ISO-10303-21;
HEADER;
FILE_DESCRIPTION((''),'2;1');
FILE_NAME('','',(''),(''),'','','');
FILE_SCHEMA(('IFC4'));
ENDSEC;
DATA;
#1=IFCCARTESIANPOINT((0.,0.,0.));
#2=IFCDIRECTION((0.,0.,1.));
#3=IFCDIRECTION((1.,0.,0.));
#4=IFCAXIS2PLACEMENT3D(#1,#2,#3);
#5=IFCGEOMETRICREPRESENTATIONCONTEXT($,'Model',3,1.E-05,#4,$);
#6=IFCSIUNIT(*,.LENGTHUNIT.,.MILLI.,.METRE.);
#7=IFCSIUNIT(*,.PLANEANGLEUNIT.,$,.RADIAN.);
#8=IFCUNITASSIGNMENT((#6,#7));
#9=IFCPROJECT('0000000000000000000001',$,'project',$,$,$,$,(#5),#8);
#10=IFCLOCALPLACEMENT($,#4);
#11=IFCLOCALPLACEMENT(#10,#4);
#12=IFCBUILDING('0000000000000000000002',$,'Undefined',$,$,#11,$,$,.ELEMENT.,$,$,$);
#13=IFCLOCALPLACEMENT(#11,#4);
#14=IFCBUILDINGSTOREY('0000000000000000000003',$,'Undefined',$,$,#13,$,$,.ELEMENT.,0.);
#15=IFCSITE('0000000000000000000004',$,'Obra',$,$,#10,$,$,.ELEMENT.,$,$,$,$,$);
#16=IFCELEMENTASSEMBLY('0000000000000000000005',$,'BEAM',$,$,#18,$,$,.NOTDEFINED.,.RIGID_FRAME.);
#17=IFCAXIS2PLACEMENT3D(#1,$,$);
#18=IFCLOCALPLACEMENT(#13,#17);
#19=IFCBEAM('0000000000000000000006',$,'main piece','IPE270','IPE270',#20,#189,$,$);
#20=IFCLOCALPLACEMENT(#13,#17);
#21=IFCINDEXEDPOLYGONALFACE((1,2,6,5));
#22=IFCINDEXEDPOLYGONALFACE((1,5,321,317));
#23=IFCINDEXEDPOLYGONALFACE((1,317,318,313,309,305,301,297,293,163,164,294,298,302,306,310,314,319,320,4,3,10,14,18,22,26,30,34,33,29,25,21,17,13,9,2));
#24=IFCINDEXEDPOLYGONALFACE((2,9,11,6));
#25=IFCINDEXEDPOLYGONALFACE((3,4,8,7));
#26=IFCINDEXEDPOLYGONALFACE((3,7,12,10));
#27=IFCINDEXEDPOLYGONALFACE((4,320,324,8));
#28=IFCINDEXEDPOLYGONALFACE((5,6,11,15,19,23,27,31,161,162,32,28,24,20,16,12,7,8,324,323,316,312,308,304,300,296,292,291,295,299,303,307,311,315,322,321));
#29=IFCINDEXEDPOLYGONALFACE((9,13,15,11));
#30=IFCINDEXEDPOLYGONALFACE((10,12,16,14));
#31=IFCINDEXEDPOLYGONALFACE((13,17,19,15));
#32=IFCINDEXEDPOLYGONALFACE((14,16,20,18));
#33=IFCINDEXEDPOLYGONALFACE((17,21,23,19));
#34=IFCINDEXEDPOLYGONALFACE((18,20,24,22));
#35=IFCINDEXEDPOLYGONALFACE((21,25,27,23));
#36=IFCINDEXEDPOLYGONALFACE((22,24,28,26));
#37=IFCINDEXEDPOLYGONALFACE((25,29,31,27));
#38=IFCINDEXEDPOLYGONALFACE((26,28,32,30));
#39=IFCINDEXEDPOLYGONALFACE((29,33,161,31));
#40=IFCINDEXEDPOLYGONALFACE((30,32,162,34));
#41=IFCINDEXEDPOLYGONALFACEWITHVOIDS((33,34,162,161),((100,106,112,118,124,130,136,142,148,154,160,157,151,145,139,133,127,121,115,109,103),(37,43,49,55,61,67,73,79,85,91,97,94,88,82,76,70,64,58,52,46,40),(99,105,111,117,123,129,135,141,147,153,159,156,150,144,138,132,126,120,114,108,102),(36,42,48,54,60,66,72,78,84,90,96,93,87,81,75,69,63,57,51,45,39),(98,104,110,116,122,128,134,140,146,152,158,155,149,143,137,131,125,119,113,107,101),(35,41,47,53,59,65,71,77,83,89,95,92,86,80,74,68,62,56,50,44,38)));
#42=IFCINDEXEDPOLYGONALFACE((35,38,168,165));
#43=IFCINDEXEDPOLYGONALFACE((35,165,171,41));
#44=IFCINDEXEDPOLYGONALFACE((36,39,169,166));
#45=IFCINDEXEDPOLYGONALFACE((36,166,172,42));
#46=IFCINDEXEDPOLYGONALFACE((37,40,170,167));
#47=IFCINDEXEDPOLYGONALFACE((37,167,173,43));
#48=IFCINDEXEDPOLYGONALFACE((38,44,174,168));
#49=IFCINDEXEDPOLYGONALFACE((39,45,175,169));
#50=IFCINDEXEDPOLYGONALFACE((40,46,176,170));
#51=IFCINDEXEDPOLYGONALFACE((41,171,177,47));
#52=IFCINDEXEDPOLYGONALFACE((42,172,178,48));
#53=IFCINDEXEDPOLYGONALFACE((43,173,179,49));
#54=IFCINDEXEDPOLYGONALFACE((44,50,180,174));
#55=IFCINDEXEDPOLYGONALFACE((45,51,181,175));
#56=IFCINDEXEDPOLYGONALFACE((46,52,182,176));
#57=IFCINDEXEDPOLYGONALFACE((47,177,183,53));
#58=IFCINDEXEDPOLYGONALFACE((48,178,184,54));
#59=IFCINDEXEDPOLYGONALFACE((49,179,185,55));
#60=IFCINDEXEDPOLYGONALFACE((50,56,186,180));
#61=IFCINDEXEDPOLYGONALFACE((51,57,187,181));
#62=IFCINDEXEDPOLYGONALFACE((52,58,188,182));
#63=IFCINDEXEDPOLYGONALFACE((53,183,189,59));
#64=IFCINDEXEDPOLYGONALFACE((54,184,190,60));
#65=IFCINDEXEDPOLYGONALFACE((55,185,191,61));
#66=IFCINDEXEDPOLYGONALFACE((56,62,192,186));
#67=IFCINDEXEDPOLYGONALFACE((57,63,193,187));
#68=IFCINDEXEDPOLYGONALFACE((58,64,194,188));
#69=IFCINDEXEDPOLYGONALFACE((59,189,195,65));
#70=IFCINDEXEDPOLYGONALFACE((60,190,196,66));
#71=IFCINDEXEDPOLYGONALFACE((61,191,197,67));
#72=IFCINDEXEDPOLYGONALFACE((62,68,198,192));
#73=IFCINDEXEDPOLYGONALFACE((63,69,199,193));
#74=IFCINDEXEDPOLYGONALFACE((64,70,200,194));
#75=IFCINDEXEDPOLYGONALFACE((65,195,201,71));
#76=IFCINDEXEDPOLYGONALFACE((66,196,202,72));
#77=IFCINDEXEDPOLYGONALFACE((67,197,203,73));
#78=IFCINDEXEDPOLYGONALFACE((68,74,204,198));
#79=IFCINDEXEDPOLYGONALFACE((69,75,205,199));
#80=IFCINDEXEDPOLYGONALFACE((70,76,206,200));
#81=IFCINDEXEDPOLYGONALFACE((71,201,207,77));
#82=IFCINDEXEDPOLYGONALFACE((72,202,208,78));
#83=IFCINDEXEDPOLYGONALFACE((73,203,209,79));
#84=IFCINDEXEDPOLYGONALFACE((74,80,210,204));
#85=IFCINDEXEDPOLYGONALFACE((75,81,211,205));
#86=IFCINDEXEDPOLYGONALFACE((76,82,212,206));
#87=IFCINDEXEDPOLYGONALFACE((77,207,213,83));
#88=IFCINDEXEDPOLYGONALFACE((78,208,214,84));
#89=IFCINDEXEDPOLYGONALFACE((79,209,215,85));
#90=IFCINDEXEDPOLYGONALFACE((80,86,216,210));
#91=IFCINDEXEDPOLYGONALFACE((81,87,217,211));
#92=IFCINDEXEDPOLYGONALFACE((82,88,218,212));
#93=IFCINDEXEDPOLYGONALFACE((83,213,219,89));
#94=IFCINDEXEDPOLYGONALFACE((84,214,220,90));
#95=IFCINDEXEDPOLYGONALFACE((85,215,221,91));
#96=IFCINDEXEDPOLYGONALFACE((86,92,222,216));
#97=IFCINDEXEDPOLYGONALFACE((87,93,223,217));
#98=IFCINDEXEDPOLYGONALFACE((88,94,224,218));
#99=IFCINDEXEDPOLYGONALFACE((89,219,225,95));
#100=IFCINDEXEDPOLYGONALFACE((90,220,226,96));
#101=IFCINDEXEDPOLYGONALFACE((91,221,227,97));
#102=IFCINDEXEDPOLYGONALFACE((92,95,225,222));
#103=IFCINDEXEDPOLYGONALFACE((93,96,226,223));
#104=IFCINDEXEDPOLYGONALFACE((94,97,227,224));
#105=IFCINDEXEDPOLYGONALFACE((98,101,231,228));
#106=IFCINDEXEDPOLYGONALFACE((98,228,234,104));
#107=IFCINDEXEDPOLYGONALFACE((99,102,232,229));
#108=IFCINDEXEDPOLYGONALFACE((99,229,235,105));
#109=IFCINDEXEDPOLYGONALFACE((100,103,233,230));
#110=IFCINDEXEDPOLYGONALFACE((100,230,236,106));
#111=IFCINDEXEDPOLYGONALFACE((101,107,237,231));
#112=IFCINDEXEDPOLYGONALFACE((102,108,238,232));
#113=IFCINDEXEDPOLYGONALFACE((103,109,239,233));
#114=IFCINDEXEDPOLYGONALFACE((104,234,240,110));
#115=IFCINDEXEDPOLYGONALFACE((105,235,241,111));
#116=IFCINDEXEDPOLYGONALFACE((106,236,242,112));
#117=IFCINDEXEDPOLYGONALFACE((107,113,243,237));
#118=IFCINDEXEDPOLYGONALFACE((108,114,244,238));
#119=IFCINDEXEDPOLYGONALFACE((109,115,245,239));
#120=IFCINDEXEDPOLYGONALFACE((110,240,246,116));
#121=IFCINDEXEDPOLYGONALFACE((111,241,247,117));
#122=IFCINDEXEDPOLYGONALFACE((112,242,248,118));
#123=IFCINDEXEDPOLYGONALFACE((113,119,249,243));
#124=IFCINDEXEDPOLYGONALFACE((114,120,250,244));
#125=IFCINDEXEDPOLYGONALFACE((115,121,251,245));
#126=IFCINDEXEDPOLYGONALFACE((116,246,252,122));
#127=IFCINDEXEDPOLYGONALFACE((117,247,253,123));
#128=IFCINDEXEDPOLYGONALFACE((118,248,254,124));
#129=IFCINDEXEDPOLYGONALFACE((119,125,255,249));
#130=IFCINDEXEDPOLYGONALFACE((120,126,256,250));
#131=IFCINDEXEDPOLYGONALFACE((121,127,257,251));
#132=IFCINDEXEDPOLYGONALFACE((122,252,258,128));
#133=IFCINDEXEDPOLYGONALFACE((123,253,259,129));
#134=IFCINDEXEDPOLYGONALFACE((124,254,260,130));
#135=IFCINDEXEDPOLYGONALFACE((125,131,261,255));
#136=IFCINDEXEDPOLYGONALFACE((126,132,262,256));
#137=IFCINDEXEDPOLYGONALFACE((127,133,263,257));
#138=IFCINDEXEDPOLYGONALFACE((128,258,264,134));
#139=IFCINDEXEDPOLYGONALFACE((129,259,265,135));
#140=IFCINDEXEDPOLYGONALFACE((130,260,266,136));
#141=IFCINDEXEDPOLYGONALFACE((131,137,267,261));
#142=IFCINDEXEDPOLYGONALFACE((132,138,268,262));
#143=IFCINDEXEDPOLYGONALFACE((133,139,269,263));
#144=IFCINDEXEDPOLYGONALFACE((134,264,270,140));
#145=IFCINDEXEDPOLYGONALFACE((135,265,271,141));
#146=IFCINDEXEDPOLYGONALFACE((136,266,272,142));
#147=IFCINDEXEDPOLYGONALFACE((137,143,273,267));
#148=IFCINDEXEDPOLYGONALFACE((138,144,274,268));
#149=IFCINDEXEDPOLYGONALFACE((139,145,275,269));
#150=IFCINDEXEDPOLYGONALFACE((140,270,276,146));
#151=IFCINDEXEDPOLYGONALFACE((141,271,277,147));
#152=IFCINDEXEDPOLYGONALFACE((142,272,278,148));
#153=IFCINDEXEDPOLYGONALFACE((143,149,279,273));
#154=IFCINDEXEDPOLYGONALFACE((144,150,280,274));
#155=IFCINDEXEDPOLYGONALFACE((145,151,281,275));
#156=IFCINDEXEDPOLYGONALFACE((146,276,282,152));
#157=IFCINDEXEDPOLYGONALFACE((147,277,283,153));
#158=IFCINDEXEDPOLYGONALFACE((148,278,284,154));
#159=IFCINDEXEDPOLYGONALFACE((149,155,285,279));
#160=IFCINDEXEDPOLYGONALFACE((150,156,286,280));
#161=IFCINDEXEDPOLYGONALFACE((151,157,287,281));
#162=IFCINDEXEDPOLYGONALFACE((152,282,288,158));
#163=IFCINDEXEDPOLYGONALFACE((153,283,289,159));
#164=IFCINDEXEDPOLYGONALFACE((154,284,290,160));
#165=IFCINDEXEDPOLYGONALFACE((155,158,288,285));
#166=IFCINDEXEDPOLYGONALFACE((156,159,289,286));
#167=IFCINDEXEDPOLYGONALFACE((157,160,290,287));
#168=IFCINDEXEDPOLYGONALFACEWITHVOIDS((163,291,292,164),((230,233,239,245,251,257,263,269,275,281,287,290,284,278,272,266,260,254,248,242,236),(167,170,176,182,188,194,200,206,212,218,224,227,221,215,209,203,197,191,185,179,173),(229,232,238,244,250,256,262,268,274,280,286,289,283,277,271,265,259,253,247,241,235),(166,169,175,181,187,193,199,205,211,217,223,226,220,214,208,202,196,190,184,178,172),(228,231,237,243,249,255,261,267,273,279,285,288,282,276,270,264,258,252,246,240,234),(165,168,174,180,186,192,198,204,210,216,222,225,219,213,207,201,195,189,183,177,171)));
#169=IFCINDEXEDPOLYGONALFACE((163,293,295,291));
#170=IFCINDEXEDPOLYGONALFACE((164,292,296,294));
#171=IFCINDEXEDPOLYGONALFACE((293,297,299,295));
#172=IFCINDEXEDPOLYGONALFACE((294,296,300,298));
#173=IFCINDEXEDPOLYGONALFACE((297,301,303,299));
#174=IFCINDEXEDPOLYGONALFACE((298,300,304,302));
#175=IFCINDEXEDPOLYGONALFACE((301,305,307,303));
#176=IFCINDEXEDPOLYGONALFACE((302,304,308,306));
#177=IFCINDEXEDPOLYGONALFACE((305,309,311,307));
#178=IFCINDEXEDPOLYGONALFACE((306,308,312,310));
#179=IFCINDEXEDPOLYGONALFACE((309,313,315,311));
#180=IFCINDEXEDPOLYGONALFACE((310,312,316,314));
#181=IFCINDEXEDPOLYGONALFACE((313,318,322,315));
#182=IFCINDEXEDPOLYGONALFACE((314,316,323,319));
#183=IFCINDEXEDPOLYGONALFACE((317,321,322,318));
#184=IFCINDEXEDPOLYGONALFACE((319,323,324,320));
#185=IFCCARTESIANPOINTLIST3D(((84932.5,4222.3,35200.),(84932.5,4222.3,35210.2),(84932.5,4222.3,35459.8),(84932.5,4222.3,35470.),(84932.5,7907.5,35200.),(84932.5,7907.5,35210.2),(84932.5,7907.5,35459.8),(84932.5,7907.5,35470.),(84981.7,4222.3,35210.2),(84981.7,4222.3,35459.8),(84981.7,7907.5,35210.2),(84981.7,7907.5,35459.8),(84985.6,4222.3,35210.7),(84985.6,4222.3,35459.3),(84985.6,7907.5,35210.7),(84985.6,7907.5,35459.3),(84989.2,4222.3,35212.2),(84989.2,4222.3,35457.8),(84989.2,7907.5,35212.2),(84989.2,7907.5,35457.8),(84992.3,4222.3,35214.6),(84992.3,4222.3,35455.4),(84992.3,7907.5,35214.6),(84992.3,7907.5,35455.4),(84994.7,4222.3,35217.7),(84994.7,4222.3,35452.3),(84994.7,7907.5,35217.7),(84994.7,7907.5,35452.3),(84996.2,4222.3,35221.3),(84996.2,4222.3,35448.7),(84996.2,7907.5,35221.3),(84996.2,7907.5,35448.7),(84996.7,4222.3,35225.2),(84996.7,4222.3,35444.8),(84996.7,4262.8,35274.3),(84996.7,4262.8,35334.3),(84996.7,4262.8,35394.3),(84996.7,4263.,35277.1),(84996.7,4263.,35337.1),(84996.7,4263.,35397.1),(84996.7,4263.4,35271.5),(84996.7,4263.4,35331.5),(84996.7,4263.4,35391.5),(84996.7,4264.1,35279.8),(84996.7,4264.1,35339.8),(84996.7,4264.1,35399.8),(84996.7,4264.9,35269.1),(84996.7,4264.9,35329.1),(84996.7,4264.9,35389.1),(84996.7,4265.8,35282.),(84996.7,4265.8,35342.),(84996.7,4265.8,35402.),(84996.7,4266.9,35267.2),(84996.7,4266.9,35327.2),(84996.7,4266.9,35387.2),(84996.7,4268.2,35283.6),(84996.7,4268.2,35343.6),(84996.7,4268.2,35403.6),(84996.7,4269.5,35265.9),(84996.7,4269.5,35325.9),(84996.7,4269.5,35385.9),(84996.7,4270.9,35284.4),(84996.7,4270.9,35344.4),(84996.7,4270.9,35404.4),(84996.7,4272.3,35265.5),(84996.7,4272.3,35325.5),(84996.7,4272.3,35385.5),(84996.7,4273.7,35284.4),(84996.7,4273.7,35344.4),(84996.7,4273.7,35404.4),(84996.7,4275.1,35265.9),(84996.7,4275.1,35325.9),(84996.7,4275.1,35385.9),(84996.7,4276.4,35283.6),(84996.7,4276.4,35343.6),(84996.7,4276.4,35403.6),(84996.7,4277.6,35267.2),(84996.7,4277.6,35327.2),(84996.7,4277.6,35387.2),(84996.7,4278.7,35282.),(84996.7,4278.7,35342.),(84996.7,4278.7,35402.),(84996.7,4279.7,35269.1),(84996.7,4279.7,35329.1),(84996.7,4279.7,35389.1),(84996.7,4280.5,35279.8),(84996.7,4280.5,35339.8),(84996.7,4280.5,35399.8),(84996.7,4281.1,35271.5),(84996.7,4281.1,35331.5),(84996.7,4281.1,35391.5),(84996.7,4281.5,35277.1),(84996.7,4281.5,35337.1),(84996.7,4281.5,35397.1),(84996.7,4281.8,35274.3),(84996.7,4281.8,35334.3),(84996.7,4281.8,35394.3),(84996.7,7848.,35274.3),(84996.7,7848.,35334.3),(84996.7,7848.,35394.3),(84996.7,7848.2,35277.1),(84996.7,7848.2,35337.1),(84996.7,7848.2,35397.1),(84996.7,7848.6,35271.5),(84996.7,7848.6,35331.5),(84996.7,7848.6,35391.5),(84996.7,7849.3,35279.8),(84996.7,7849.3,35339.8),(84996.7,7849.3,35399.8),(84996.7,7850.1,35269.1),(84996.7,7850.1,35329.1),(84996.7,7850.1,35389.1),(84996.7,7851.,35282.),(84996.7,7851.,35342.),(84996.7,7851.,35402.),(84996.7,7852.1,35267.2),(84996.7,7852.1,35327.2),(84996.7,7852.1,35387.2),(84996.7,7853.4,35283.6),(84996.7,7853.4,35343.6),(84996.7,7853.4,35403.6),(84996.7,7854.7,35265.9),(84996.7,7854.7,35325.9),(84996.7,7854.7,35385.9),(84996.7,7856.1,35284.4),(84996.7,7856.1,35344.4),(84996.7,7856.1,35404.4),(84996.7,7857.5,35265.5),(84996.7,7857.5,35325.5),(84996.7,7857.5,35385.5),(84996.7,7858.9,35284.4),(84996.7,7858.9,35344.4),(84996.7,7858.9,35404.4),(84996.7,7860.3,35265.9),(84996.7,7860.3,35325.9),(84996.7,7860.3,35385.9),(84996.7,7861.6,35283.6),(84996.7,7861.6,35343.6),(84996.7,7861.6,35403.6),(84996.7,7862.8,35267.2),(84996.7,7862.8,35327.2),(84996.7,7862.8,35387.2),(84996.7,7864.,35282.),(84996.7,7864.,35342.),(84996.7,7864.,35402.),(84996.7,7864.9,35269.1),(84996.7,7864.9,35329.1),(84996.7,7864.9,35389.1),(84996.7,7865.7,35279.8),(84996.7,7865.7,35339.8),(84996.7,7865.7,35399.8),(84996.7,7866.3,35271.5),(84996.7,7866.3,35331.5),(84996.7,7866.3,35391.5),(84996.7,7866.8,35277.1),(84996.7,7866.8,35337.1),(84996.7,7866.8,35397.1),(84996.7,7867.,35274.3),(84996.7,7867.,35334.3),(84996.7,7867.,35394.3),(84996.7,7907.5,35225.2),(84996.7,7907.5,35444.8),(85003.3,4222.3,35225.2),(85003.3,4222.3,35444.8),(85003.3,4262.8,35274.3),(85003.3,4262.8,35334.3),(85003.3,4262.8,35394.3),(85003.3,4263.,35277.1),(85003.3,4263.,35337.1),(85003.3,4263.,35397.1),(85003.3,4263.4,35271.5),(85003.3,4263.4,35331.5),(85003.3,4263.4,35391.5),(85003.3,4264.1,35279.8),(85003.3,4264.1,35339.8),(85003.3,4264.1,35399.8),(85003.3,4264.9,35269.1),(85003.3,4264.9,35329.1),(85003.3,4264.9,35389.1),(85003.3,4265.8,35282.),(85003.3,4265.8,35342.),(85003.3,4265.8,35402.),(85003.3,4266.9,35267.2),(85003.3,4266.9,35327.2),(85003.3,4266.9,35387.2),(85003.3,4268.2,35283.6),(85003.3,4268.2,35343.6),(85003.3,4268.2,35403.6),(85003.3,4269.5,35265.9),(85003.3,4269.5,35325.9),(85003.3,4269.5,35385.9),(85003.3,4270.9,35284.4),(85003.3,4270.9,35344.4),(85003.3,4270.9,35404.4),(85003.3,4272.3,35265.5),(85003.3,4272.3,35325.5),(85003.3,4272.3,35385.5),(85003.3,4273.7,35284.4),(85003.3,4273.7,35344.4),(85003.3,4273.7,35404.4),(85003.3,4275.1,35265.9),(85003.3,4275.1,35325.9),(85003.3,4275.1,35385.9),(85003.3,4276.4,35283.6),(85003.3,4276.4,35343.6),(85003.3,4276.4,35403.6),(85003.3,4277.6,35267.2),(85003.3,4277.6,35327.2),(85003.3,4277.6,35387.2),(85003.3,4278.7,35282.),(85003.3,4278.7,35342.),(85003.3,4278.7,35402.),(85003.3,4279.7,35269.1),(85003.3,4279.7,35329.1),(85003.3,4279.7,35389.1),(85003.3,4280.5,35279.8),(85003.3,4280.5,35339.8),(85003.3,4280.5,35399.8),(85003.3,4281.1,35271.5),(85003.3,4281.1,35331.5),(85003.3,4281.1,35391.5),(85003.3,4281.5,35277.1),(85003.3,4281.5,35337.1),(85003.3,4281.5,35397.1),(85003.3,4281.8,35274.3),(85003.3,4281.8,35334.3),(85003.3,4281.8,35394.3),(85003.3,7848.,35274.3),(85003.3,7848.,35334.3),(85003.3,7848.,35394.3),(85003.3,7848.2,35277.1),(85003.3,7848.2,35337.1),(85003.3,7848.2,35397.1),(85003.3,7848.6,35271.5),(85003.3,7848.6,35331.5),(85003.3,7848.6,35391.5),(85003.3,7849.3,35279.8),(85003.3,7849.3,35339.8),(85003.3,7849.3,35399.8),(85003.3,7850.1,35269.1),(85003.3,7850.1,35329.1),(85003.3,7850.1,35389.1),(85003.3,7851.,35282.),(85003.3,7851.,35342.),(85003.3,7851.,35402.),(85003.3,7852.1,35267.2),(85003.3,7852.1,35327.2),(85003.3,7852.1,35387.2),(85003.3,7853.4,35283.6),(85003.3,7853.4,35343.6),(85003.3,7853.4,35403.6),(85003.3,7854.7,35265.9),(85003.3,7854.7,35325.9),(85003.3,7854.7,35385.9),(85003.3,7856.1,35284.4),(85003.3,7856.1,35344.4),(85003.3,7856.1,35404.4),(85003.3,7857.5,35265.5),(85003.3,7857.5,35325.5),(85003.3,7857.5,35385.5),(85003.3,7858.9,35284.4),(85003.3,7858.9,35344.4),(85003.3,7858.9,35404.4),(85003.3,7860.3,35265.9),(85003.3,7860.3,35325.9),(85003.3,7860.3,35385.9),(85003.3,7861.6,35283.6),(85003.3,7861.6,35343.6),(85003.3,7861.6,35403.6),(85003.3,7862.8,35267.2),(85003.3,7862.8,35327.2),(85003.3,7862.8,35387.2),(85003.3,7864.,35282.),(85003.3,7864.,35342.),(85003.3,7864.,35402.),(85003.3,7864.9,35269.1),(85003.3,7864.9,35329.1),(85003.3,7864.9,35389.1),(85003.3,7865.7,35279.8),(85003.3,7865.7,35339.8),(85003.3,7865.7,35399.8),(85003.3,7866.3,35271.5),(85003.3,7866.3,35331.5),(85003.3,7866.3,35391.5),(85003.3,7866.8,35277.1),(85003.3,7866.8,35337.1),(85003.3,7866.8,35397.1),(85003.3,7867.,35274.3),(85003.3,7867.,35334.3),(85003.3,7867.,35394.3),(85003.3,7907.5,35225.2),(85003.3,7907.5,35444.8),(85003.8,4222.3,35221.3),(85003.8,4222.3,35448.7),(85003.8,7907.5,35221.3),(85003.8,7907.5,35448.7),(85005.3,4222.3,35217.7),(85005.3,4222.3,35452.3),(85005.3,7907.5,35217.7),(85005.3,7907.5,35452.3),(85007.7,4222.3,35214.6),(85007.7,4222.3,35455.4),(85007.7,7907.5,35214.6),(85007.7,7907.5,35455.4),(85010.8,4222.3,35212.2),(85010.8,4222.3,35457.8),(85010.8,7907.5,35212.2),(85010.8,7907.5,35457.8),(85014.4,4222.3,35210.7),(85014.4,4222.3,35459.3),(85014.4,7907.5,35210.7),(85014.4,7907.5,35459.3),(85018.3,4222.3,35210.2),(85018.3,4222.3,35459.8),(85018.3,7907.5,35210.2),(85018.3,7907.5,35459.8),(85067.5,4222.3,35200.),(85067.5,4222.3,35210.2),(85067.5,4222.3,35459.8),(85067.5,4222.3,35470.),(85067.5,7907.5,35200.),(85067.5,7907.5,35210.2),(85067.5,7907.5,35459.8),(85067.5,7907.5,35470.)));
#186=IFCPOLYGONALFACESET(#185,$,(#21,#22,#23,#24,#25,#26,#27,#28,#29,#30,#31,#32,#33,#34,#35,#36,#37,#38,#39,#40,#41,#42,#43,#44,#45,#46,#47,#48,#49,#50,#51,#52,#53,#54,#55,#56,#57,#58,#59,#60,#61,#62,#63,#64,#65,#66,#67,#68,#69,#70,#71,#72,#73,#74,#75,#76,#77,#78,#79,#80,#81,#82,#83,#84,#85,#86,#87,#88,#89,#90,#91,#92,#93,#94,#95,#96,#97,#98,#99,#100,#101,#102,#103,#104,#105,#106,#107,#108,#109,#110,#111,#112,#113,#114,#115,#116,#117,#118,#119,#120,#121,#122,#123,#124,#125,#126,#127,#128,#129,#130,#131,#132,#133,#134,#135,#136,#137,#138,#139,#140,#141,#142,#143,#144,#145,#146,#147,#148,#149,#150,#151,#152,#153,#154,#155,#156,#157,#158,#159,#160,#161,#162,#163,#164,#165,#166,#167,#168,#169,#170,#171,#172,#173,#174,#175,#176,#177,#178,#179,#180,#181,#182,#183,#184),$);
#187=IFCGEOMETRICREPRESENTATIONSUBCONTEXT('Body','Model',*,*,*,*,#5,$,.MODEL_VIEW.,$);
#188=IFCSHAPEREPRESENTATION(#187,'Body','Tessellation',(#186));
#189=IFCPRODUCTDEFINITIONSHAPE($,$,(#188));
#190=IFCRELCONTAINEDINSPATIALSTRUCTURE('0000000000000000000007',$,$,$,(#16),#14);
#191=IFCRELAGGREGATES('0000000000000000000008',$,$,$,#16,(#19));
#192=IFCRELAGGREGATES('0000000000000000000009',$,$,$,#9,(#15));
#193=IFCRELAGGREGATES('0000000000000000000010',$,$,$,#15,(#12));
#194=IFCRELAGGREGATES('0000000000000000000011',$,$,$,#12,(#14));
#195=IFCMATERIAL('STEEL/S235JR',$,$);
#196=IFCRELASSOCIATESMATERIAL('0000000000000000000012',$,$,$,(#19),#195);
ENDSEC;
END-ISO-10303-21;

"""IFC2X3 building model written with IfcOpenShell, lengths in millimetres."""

from ifc_helpers import new_model, si_unit, frame, origin_with_axes, origin_2d_with_axis, place, context, subcontext, project, spatial, circle, i_section, extrude, clip, halfspace, source, transform, mapped, material, element, aggregate, save


model = new_model("IFC2X3")

# Units and contexts
model_context = context("Model", 3, precision=1e-05, world=origin_with_axes())
body_context = subcontext(model_context, "Body", "Model", "MODEL_VIEW")
ifc_project = project(units=[si_unit("LENGTHUNIT", "METRE", prefix="MILLI"), si_unit("PLANEANGLEUNIT", "RADIAN")], contexts=[model_context])

# Site, building, storey
site_placement = place(None, origin_with_axes())
site = spatial("IfcSite", under=ifc_project, at=site_placement, Name="Obra", CompositionType="ELEMENT")
building_placement = place(site_placement, origin_with_axes())
building = spatial("IfcBuilding", under=site, at=building_placement, Name="Undefined", CompositionType="ELEMENT")
storey_placement = place(building_placement, origin_with_axes())
storey = spatial("IfcBuildingStorey", under=building, at=storey_placement, Name="Undefined", CompositionType="ELEMENT", Elevation=0.0)

# Shared definitions
ifc_material_1 = material(Name="STEEL/S235JR")

# Element assembly, beam, openings
assembly_1_placement = place(storey_placement, origin_with_axes())
assembly_1 = element("IfcElementAssembly", 1, at=assembly_1_placement, inside=storey, Name="BEAM", AssemblyPlace="NOTDEFINED", PredefinedType="RIGID_FRAME")
beam_1_placement = place(assembly_1_placement, frame((85000.0, 7995.2, 35335.0), z_axis=(0.0, 0.0, 1.0), x_axis=(0.000005, -1.0, 0.0)))
beam_1 = element("IfcBeam", 2, at=beam_1_placement, material=ifc_material_1, Name="main piece", Description="IPE270", ObjectType="IPE270", context=body_context, shape_type="Clipping", body=[
    clip(clip(extrude(i_section(OverallWidth=135.0, OverallDepth=270.0, WebThickness=6.6, FlangeThickness=10.2, FilletRadius=15.0, at=origin_2d_with_axis()), frame((3772.9, 0.0, 0.0), z_axis=(-1.0, 0.0, 0.0), x_axis=(0.0, -1.0, 0.0)), (0.0, 0.0, 1.0), 3685.2), halfspace(frame((3772.9, 0.0, -235.0), z_axis=(-1.0, 0.000005, 0.0), x_axis=(0.000005, 1.0, 0.0)), True)), halfspace(frame((87.7, 0.0, -235.0), z_axis=(1.0, -0.000005, 0.0), x_axis=(-0.000005, -1.0, 0.0)), True)),
])
shared_shape_1 = source(origin_with_axes(), body_context, "Body", "SweptSolid", [
    extrude(circle(Radius=9.5, at=origin_2d_with_axis()), frame((0.0, -3.4, 0.0), z_axis=(0.0, 1.0, 0.0), x_axis=(1.0, 0.0, 0.0)), (0.0, 0.0, 1.0), 6.8),
])
opening_1_placement = place(assembly_1_placement, frame((85000.0, 7907.5, 35470.0), z_axis=(0.0, -1.0, 0.0), x_axis=(0.0, 0.0, -1.0)))
element("IfcOpeningElement", 3, at=opening_1_placement, cuts=beam_1, ObjectType="Opening", context=body_context, shape_type="MappedRepresentation", body=[
    mapped(shared_shape_1, transform((75.0, 0.0, 50.0))),
    mapped(shared_shape_1, transform((135.0, 0.0, 50.0))),
    mapped(shared_shape_1, transform((195.0, 0.0, 50.0))),
])
opening_2_placement = place(assembly_1_placement, frame((85000.0, 4222.3, 35470.0), z_axis=(0.0, 1.0, 0.0), x_axis=(0.0, 0.0, -1.0)))
element("IfcOpeningElement", 4, at=opening_2_placement, cuts=beam_1, ObjectType="Opening", context=body_context, shape_type="MappedRepresentation", body=[
    mapped(shared_shape_1, transform((75.0, 0.0, 50.0))),
    mapped(shared_shape_1, transform((135.0, 0.0, 50.0))),
    mapped(shared_shape_1, transform((195.0, 0.0, 50.0))),
])

aggregate(assembly_1, [beam_1])

save(model, "model.ifc")
